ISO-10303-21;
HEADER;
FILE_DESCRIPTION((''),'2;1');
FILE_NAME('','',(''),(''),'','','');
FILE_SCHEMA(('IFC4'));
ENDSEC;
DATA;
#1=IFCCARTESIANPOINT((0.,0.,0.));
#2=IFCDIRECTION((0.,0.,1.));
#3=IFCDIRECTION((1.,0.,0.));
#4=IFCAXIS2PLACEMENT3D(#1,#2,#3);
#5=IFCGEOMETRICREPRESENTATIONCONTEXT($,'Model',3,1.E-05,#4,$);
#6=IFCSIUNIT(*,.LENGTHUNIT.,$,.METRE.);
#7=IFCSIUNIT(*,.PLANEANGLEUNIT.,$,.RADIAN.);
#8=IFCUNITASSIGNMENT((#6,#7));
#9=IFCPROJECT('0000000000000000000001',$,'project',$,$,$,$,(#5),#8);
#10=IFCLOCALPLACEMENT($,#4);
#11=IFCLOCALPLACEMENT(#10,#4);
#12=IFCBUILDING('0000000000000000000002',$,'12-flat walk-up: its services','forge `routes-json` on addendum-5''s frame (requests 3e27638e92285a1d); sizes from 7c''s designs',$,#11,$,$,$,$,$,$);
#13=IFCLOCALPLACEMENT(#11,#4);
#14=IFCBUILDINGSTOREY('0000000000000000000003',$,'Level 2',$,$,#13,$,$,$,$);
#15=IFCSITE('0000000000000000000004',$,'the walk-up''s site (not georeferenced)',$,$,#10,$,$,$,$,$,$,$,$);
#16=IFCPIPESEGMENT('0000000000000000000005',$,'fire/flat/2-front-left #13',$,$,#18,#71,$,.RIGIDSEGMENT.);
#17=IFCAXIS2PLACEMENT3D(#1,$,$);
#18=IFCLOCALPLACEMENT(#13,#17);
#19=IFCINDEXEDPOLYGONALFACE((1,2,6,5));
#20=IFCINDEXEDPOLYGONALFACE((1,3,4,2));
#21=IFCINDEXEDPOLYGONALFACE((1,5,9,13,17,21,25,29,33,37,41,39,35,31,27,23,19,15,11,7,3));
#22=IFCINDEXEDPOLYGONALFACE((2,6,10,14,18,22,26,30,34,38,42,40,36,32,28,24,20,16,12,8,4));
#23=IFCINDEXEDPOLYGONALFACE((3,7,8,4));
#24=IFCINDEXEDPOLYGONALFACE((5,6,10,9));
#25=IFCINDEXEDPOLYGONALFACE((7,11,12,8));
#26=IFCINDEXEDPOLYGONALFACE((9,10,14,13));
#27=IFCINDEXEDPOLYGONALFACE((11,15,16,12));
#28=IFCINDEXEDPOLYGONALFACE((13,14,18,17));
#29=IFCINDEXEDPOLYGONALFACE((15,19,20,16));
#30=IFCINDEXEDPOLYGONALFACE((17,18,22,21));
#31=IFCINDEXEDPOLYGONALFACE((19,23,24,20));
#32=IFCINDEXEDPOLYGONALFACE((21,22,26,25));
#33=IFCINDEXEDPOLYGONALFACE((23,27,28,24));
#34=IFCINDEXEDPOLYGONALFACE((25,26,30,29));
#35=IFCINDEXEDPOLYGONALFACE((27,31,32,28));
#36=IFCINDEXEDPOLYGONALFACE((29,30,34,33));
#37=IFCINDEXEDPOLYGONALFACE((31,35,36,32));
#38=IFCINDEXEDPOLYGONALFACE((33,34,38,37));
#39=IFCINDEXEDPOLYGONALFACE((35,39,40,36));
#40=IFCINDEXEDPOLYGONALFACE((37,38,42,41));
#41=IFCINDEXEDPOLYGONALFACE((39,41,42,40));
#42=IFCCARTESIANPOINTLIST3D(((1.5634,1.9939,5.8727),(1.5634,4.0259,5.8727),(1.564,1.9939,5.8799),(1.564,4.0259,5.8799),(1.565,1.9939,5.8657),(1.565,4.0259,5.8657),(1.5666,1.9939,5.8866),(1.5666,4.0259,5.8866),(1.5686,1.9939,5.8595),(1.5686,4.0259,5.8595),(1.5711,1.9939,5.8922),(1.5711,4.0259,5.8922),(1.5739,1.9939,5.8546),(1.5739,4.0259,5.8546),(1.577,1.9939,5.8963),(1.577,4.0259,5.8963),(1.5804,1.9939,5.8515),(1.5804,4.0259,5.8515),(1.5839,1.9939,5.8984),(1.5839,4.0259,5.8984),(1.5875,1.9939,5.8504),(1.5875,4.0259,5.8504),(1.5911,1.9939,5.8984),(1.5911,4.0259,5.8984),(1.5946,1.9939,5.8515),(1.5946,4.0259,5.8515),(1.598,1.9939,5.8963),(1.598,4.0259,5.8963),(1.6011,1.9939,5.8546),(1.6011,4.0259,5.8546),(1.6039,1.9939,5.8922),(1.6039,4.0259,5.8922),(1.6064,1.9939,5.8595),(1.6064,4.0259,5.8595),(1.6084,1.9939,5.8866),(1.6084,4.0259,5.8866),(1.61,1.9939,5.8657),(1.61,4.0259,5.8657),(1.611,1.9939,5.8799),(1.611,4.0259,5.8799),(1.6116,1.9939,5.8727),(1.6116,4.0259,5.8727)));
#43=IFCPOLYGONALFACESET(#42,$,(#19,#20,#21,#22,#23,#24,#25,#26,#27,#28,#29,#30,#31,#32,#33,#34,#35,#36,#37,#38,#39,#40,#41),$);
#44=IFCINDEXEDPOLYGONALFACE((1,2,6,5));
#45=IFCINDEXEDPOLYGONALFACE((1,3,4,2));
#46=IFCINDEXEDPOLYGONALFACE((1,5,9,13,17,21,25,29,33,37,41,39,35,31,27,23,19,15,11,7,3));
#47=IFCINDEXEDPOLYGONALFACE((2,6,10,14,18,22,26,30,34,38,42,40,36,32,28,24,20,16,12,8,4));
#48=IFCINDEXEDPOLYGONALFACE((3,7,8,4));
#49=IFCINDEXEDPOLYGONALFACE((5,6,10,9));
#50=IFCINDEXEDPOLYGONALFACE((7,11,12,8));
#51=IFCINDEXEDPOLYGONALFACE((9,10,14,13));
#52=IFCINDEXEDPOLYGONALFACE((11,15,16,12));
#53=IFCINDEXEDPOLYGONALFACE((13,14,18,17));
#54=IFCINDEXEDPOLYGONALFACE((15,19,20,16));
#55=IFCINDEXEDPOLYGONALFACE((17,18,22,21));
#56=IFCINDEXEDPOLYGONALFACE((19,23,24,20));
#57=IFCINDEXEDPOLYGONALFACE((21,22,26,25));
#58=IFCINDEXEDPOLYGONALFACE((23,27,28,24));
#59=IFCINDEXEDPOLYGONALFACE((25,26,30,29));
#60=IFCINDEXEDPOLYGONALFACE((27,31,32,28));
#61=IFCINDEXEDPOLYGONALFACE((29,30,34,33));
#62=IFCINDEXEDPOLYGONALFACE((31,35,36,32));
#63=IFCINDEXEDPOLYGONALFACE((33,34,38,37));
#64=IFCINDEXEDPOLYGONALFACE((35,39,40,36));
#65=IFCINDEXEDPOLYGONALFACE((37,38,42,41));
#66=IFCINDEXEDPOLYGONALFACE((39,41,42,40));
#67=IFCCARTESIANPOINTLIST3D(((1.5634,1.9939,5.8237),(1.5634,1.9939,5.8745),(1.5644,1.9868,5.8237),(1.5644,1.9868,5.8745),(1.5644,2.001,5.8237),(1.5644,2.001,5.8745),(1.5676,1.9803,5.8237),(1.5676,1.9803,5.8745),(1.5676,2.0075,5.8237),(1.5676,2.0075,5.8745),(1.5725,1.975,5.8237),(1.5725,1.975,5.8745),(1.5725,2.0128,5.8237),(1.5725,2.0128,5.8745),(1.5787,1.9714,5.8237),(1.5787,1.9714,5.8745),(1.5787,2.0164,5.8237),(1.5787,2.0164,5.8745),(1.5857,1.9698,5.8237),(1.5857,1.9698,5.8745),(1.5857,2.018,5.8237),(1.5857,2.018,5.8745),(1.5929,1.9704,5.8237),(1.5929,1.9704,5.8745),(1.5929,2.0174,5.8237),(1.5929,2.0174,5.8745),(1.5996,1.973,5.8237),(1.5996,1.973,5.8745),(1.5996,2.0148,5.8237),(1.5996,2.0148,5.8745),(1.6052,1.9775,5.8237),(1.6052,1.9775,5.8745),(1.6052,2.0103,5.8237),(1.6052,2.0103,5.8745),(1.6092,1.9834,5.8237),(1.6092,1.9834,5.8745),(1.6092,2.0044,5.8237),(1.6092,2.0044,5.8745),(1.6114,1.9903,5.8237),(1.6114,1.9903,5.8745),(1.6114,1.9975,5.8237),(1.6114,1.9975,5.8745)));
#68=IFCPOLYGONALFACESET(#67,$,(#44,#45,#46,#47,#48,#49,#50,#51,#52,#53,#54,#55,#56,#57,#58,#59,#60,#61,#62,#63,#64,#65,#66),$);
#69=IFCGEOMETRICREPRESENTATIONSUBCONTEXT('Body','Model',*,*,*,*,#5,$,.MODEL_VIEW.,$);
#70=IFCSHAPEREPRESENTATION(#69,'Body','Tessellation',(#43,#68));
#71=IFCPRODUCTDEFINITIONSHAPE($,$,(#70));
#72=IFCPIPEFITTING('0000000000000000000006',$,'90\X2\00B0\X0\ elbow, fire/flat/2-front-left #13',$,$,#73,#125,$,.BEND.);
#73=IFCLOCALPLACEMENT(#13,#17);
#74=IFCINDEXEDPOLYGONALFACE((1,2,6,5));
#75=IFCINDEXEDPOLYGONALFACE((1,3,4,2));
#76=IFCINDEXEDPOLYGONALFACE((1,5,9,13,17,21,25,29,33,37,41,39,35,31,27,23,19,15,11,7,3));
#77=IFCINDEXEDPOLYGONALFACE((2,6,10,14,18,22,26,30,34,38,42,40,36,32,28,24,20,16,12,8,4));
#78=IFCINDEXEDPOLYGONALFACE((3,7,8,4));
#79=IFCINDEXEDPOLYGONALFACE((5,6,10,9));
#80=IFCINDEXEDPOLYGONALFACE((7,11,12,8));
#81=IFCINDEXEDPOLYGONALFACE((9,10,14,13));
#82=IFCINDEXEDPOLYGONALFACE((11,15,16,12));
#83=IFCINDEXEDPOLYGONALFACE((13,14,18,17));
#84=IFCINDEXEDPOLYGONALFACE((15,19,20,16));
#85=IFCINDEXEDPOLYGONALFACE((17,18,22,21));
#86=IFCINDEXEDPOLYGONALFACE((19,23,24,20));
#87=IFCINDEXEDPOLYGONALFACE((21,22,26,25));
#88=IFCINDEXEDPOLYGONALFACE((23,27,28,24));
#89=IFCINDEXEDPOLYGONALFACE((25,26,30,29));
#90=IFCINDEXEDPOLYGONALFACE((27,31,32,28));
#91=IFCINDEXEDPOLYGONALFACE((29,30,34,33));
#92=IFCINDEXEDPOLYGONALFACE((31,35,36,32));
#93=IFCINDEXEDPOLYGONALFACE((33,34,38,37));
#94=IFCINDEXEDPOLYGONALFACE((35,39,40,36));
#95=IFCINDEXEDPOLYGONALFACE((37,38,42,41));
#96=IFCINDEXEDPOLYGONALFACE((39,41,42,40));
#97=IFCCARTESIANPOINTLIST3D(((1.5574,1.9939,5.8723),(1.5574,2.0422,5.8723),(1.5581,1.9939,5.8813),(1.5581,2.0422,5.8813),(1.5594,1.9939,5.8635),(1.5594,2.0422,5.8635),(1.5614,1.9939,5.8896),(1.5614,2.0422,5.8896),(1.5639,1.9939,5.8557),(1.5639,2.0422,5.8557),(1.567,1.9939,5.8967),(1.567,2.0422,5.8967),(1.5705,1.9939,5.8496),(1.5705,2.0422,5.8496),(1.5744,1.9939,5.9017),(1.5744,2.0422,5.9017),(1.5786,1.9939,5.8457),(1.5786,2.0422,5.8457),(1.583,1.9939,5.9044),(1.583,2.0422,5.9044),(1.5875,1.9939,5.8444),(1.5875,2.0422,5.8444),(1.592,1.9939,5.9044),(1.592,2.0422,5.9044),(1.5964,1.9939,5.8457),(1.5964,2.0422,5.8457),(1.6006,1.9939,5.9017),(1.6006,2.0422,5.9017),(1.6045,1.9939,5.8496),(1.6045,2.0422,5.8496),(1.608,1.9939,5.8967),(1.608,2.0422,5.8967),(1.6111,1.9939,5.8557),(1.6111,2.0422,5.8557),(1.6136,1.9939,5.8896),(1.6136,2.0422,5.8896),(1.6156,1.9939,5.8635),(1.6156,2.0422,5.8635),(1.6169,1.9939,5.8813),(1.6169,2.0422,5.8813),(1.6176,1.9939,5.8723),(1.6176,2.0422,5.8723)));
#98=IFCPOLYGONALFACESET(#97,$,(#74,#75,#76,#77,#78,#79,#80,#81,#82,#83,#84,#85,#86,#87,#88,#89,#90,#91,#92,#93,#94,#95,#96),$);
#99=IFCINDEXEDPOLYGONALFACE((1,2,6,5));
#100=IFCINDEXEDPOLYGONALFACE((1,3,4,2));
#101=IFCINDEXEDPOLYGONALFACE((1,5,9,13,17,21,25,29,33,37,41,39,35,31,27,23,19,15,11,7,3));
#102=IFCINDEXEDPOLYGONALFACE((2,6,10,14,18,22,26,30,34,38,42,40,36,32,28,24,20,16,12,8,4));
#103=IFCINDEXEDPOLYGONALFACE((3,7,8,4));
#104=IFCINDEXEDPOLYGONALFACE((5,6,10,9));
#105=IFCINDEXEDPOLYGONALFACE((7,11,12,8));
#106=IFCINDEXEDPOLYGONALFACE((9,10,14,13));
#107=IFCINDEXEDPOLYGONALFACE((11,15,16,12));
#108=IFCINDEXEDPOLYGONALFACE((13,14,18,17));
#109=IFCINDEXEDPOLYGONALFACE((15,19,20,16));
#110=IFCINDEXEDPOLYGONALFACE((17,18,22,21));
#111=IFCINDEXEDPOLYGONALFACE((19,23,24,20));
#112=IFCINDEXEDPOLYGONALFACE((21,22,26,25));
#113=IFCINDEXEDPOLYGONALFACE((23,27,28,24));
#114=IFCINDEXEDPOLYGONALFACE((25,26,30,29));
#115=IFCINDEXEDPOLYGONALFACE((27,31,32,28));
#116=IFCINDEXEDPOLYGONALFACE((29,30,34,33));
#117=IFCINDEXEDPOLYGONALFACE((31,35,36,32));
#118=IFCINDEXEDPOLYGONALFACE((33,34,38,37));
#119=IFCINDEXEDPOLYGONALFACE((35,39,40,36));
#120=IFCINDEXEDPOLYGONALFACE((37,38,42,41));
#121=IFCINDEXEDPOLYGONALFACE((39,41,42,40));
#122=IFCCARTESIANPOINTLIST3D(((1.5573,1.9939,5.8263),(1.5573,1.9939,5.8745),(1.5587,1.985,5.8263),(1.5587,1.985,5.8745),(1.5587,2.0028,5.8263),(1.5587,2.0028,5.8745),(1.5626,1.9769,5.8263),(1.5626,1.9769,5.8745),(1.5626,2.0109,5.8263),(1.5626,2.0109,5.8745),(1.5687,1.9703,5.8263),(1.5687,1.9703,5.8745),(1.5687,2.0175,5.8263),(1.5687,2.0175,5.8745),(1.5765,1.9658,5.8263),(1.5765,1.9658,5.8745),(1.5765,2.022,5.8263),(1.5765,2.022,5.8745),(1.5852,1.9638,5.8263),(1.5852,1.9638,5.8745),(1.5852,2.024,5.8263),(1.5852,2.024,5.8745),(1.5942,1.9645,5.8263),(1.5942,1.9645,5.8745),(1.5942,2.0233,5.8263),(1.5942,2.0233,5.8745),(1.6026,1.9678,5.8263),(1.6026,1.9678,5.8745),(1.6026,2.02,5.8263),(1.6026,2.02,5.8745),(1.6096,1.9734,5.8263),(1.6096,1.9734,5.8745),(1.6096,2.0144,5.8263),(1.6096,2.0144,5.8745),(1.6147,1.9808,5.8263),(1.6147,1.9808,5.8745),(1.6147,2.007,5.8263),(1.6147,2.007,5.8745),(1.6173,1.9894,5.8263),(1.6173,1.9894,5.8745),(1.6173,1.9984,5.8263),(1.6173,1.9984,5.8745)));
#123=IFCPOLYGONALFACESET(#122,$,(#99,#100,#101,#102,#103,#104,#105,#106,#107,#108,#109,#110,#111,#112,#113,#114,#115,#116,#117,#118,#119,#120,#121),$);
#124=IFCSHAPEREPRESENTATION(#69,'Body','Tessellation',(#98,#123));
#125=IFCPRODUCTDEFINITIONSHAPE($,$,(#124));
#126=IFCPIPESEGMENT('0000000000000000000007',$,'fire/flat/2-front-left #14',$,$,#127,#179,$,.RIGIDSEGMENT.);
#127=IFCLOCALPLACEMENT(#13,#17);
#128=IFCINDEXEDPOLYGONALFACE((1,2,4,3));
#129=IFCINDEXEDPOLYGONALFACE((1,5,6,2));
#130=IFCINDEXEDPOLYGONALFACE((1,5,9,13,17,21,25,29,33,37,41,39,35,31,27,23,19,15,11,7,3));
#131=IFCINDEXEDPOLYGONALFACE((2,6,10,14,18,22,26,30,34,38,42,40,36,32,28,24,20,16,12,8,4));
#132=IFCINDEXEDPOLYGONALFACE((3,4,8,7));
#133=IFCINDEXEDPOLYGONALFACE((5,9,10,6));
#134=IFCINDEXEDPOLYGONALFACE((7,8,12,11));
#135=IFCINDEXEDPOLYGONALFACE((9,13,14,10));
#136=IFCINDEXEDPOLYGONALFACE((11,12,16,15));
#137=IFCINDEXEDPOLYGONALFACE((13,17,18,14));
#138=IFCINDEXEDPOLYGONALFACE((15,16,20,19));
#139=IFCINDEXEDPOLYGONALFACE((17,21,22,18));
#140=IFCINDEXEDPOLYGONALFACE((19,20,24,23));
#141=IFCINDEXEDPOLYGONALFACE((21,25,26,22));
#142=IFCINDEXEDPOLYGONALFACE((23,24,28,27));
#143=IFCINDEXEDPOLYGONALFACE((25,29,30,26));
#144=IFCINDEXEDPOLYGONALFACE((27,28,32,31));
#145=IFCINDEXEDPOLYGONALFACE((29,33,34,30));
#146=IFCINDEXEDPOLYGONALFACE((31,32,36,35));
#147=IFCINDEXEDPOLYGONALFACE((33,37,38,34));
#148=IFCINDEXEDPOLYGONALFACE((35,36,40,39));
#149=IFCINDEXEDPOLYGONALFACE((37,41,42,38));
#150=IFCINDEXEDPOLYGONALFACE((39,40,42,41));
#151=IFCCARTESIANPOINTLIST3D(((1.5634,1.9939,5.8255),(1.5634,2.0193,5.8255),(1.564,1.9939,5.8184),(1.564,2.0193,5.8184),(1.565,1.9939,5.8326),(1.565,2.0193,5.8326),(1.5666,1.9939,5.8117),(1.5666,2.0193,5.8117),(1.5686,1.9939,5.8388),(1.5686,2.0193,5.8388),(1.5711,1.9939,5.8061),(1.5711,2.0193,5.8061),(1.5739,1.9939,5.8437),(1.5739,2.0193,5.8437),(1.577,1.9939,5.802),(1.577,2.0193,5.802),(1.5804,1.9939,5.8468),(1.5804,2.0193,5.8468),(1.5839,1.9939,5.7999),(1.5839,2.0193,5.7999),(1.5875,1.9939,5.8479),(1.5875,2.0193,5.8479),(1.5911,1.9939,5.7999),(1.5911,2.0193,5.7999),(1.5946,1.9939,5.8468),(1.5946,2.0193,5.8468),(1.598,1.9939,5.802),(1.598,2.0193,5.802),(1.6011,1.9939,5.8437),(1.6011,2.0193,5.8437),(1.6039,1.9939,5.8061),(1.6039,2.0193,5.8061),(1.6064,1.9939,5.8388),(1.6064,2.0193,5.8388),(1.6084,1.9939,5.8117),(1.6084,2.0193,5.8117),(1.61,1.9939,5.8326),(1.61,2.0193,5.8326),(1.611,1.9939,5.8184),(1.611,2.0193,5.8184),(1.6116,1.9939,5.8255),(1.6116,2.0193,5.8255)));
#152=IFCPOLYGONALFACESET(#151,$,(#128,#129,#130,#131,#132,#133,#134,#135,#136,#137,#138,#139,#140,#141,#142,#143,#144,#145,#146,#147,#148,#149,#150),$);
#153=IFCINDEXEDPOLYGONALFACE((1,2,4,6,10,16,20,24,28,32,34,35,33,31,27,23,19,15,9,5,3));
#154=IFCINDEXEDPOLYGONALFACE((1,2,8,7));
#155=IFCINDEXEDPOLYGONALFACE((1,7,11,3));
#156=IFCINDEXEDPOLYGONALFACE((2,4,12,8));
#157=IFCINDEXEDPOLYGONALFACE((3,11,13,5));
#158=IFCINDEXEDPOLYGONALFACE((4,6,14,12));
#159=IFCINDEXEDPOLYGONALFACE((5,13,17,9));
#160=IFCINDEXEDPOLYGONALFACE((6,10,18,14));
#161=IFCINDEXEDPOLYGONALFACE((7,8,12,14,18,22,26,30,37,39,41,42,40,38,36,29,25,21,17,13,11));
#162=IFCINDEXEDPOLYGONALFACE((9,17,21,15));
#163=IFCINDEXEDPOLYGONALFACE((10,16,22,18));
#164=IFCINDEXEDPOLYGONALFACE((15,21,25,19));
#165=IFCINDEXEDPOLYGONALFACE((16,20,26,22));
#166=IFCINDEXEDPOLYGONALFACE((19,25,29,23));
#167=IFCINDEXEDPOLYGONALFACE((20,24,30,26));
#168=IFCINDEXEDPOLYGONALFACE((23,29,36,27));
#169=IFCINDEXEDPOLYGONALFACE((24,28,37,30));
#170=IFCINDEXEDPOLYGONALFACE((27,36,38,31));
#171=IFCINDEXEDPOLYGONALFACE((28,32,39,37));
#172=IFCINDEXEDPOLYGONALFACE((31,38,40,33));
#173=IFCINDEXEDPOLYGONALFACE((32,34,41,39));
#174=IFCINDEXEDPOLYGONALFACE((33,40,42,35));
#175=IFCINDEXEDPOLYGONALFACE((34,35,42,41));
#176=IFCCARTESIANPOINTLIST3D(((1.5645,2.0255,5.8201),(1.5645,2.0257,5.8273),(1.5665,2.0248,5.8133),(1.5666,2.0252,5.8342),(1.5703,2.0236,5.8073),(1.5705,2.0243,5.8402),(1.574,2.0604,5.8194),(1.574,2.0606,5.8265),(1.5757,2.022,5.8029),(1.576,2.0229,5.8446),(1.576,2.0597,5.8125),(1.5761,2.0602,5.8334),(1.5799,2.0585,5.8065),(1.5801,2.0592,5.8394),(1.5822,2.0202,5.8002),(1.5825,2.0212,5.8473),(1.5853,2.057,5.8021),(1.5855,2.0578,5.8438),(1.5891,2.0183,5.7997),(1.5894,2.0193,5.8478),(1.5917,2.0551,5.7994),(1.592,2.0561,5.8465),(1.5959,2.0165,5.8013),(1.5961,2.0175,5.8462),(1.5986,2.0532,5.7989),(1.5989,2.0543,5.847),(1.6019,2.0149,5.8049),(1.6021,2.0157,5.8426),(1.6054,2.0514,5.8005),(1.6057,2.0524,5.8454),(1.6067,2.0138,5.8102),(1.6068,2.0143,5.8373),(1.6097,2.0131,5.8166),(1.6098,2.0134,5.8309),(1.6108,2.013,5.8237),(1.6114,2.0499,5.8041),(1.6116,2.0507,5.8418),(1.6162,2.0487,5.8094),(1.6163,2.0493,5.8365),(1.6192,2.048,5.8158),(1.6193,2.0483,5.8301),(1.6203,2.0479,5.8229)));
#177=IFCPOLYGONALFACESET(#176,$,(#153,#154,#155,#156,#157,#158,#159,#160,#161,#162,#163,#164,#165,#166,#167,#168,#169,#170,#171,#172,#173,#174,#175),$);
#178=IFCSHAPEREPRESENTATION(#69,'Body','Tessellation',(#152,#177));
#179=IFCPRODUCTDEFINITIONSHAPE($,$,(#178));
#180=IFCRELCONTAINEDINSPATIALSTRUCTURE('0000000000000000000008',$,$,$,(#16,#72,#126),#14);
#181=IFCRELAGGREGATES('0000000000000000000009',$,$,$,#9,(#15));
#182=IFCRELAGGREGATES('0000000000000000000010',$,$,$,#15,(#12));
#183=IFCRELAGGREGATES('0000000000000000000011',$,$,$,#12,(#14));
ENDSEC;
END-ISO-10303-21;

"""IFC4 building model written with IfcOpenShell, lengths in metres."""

from ifc_helpers import new_model, entity, si_unit, frame, origin_with_axes, place, context, subcontext, project, spatial, element, save


model = new_model("IFC4")

# Units and contexts
model_context = context("Model", 3, precision=1e-05, world=origin_with_axes())
body_context = subcontext(model_context, "Body", "Model", "MODEL_VIEW")
ifc_project = project(units=[si_unit("LENGTHUNIT", "METRE"), si_unit("PLANEANGLEUNIT", "RADIAN")], contexts=[model_context])

# Site, building, storey
site_placement = place(None, origin_with_axes())
site = spatial("IfcSite", under=ifc_project, at=site_placement, Name="the walk-up's site (not georeferenced)")
building_placement = place(site_placement, origin_with_axes())
building = spatial("IfcBuilding", under=site, at=building_placement, Name="12-flat walk-up: its services", Description="forge `routes-json` on addendum-5's frame (requests 3e27638e92285a1d); sizes from 7c's designs")
storey_placement = place(building_placement, origin_with_axes())
storey = spatial("IfcBuildingStorey", under=building, at=storey_placement, Name="Level 2")

# Pipe segment
pipe_segment_1_placement = place(storey_placement, frame((1.5875, 4.0259, 5.8745), z_axis=(0.0, 0.0, 1.0), x_axis=(1.0, 0.0, 0.0)))
element("IfcPipeSegment", 1, at=pipe_segment_1_placement, inside=storey, Name="fire/flat/2-front-left #13", PredefinedType="RIGIDSEGMENT", context=body_context, shape_type="AdvancedSweptSolid", body=[
    entity("IfcSweptDiskSolid", entity("IfcPolyline", [entity("IfcCartesianPoint", [0.0, 0.0, 0.0]), entity("IfcCartesianPoint", [0.0, -2.032, 0.0])]), 0.0241),
    entity("IfcSweptDiskSolid", entity("IfcPolyline", [entity("IfcCartesianPoint", [0.0, -2.032, 0.0]), entity("IfcCartesianPoint", [0.0, -2.032, -0.0508])]), 0.0241),
])

# Pipe fitting
pipe_fitting_1_placement = place(storey_placement, frame((1.5875, 2.0422, 5.8745), z_axis=(0.0, 0.0, 1.0), x_axis=(1.0, 0.0, 0.0)))
element("IfcPipeFitting", 2, at=pipe_fitting_1_placement, inside=storey, Name="90° elbow, fire/flat/2-front-left #13", PredefinedType="BEND", context=body_context, shape_type="AdvancedSweptSolid", body=[
    entity("IfcSweptDiskSolid", entity("IfcPolyline", [entity("IfcCartesianPoint", [0.0, 0.0, 0.0]), entity("IfcCartesianPoint", [0.0, -0.0483, 0.0])]), 0.0302),
    entity("IfcSweptDiskSolid", entity("IfcPolyline", [entity("IfcCartesianPoint", [0.0, -0.0483, 0.0]), entity("IfcCartesianPoint", [0.0, -0.0483, -0.0483])]), 0.0302),
])

# Pipe segment
pipe_segment_2_placement = place(storey_placement, frame((1.5875, 1.9939, 5.8237), z_axis=(0.0, 0.0, 1.0), x_axis=(1.0, 0.0, 0.0)))
element("IfcPipeSegment", 3, at=pipe_segment_2_placement, inside=storey, Name="fire/flat/2-front-left #14", PredefinedType="RIGIDSEGMENT", context=body_context, shape_type="AdvancedSweptSolid", body=[
    entity("IfcSweptDiskSolid", entity("IfcPolyline", [entity("IfcCartesianPoint", [0.0, 0.0, 0.0]), entity("IfcCartesianPoint", [0.0, 0.0254, 0.0])]), 0.0241),
    entity("IfcSweptDiskSolid", entity("IfcPolyline", [entity("IfcCartesianPoint", [0.0, 0.0254, 0.0]), entity("IfcCartesianPoint", [0.0095, 0.0603, -0.0008])]), 0.0241),
])

save(model, "model.ifc")
